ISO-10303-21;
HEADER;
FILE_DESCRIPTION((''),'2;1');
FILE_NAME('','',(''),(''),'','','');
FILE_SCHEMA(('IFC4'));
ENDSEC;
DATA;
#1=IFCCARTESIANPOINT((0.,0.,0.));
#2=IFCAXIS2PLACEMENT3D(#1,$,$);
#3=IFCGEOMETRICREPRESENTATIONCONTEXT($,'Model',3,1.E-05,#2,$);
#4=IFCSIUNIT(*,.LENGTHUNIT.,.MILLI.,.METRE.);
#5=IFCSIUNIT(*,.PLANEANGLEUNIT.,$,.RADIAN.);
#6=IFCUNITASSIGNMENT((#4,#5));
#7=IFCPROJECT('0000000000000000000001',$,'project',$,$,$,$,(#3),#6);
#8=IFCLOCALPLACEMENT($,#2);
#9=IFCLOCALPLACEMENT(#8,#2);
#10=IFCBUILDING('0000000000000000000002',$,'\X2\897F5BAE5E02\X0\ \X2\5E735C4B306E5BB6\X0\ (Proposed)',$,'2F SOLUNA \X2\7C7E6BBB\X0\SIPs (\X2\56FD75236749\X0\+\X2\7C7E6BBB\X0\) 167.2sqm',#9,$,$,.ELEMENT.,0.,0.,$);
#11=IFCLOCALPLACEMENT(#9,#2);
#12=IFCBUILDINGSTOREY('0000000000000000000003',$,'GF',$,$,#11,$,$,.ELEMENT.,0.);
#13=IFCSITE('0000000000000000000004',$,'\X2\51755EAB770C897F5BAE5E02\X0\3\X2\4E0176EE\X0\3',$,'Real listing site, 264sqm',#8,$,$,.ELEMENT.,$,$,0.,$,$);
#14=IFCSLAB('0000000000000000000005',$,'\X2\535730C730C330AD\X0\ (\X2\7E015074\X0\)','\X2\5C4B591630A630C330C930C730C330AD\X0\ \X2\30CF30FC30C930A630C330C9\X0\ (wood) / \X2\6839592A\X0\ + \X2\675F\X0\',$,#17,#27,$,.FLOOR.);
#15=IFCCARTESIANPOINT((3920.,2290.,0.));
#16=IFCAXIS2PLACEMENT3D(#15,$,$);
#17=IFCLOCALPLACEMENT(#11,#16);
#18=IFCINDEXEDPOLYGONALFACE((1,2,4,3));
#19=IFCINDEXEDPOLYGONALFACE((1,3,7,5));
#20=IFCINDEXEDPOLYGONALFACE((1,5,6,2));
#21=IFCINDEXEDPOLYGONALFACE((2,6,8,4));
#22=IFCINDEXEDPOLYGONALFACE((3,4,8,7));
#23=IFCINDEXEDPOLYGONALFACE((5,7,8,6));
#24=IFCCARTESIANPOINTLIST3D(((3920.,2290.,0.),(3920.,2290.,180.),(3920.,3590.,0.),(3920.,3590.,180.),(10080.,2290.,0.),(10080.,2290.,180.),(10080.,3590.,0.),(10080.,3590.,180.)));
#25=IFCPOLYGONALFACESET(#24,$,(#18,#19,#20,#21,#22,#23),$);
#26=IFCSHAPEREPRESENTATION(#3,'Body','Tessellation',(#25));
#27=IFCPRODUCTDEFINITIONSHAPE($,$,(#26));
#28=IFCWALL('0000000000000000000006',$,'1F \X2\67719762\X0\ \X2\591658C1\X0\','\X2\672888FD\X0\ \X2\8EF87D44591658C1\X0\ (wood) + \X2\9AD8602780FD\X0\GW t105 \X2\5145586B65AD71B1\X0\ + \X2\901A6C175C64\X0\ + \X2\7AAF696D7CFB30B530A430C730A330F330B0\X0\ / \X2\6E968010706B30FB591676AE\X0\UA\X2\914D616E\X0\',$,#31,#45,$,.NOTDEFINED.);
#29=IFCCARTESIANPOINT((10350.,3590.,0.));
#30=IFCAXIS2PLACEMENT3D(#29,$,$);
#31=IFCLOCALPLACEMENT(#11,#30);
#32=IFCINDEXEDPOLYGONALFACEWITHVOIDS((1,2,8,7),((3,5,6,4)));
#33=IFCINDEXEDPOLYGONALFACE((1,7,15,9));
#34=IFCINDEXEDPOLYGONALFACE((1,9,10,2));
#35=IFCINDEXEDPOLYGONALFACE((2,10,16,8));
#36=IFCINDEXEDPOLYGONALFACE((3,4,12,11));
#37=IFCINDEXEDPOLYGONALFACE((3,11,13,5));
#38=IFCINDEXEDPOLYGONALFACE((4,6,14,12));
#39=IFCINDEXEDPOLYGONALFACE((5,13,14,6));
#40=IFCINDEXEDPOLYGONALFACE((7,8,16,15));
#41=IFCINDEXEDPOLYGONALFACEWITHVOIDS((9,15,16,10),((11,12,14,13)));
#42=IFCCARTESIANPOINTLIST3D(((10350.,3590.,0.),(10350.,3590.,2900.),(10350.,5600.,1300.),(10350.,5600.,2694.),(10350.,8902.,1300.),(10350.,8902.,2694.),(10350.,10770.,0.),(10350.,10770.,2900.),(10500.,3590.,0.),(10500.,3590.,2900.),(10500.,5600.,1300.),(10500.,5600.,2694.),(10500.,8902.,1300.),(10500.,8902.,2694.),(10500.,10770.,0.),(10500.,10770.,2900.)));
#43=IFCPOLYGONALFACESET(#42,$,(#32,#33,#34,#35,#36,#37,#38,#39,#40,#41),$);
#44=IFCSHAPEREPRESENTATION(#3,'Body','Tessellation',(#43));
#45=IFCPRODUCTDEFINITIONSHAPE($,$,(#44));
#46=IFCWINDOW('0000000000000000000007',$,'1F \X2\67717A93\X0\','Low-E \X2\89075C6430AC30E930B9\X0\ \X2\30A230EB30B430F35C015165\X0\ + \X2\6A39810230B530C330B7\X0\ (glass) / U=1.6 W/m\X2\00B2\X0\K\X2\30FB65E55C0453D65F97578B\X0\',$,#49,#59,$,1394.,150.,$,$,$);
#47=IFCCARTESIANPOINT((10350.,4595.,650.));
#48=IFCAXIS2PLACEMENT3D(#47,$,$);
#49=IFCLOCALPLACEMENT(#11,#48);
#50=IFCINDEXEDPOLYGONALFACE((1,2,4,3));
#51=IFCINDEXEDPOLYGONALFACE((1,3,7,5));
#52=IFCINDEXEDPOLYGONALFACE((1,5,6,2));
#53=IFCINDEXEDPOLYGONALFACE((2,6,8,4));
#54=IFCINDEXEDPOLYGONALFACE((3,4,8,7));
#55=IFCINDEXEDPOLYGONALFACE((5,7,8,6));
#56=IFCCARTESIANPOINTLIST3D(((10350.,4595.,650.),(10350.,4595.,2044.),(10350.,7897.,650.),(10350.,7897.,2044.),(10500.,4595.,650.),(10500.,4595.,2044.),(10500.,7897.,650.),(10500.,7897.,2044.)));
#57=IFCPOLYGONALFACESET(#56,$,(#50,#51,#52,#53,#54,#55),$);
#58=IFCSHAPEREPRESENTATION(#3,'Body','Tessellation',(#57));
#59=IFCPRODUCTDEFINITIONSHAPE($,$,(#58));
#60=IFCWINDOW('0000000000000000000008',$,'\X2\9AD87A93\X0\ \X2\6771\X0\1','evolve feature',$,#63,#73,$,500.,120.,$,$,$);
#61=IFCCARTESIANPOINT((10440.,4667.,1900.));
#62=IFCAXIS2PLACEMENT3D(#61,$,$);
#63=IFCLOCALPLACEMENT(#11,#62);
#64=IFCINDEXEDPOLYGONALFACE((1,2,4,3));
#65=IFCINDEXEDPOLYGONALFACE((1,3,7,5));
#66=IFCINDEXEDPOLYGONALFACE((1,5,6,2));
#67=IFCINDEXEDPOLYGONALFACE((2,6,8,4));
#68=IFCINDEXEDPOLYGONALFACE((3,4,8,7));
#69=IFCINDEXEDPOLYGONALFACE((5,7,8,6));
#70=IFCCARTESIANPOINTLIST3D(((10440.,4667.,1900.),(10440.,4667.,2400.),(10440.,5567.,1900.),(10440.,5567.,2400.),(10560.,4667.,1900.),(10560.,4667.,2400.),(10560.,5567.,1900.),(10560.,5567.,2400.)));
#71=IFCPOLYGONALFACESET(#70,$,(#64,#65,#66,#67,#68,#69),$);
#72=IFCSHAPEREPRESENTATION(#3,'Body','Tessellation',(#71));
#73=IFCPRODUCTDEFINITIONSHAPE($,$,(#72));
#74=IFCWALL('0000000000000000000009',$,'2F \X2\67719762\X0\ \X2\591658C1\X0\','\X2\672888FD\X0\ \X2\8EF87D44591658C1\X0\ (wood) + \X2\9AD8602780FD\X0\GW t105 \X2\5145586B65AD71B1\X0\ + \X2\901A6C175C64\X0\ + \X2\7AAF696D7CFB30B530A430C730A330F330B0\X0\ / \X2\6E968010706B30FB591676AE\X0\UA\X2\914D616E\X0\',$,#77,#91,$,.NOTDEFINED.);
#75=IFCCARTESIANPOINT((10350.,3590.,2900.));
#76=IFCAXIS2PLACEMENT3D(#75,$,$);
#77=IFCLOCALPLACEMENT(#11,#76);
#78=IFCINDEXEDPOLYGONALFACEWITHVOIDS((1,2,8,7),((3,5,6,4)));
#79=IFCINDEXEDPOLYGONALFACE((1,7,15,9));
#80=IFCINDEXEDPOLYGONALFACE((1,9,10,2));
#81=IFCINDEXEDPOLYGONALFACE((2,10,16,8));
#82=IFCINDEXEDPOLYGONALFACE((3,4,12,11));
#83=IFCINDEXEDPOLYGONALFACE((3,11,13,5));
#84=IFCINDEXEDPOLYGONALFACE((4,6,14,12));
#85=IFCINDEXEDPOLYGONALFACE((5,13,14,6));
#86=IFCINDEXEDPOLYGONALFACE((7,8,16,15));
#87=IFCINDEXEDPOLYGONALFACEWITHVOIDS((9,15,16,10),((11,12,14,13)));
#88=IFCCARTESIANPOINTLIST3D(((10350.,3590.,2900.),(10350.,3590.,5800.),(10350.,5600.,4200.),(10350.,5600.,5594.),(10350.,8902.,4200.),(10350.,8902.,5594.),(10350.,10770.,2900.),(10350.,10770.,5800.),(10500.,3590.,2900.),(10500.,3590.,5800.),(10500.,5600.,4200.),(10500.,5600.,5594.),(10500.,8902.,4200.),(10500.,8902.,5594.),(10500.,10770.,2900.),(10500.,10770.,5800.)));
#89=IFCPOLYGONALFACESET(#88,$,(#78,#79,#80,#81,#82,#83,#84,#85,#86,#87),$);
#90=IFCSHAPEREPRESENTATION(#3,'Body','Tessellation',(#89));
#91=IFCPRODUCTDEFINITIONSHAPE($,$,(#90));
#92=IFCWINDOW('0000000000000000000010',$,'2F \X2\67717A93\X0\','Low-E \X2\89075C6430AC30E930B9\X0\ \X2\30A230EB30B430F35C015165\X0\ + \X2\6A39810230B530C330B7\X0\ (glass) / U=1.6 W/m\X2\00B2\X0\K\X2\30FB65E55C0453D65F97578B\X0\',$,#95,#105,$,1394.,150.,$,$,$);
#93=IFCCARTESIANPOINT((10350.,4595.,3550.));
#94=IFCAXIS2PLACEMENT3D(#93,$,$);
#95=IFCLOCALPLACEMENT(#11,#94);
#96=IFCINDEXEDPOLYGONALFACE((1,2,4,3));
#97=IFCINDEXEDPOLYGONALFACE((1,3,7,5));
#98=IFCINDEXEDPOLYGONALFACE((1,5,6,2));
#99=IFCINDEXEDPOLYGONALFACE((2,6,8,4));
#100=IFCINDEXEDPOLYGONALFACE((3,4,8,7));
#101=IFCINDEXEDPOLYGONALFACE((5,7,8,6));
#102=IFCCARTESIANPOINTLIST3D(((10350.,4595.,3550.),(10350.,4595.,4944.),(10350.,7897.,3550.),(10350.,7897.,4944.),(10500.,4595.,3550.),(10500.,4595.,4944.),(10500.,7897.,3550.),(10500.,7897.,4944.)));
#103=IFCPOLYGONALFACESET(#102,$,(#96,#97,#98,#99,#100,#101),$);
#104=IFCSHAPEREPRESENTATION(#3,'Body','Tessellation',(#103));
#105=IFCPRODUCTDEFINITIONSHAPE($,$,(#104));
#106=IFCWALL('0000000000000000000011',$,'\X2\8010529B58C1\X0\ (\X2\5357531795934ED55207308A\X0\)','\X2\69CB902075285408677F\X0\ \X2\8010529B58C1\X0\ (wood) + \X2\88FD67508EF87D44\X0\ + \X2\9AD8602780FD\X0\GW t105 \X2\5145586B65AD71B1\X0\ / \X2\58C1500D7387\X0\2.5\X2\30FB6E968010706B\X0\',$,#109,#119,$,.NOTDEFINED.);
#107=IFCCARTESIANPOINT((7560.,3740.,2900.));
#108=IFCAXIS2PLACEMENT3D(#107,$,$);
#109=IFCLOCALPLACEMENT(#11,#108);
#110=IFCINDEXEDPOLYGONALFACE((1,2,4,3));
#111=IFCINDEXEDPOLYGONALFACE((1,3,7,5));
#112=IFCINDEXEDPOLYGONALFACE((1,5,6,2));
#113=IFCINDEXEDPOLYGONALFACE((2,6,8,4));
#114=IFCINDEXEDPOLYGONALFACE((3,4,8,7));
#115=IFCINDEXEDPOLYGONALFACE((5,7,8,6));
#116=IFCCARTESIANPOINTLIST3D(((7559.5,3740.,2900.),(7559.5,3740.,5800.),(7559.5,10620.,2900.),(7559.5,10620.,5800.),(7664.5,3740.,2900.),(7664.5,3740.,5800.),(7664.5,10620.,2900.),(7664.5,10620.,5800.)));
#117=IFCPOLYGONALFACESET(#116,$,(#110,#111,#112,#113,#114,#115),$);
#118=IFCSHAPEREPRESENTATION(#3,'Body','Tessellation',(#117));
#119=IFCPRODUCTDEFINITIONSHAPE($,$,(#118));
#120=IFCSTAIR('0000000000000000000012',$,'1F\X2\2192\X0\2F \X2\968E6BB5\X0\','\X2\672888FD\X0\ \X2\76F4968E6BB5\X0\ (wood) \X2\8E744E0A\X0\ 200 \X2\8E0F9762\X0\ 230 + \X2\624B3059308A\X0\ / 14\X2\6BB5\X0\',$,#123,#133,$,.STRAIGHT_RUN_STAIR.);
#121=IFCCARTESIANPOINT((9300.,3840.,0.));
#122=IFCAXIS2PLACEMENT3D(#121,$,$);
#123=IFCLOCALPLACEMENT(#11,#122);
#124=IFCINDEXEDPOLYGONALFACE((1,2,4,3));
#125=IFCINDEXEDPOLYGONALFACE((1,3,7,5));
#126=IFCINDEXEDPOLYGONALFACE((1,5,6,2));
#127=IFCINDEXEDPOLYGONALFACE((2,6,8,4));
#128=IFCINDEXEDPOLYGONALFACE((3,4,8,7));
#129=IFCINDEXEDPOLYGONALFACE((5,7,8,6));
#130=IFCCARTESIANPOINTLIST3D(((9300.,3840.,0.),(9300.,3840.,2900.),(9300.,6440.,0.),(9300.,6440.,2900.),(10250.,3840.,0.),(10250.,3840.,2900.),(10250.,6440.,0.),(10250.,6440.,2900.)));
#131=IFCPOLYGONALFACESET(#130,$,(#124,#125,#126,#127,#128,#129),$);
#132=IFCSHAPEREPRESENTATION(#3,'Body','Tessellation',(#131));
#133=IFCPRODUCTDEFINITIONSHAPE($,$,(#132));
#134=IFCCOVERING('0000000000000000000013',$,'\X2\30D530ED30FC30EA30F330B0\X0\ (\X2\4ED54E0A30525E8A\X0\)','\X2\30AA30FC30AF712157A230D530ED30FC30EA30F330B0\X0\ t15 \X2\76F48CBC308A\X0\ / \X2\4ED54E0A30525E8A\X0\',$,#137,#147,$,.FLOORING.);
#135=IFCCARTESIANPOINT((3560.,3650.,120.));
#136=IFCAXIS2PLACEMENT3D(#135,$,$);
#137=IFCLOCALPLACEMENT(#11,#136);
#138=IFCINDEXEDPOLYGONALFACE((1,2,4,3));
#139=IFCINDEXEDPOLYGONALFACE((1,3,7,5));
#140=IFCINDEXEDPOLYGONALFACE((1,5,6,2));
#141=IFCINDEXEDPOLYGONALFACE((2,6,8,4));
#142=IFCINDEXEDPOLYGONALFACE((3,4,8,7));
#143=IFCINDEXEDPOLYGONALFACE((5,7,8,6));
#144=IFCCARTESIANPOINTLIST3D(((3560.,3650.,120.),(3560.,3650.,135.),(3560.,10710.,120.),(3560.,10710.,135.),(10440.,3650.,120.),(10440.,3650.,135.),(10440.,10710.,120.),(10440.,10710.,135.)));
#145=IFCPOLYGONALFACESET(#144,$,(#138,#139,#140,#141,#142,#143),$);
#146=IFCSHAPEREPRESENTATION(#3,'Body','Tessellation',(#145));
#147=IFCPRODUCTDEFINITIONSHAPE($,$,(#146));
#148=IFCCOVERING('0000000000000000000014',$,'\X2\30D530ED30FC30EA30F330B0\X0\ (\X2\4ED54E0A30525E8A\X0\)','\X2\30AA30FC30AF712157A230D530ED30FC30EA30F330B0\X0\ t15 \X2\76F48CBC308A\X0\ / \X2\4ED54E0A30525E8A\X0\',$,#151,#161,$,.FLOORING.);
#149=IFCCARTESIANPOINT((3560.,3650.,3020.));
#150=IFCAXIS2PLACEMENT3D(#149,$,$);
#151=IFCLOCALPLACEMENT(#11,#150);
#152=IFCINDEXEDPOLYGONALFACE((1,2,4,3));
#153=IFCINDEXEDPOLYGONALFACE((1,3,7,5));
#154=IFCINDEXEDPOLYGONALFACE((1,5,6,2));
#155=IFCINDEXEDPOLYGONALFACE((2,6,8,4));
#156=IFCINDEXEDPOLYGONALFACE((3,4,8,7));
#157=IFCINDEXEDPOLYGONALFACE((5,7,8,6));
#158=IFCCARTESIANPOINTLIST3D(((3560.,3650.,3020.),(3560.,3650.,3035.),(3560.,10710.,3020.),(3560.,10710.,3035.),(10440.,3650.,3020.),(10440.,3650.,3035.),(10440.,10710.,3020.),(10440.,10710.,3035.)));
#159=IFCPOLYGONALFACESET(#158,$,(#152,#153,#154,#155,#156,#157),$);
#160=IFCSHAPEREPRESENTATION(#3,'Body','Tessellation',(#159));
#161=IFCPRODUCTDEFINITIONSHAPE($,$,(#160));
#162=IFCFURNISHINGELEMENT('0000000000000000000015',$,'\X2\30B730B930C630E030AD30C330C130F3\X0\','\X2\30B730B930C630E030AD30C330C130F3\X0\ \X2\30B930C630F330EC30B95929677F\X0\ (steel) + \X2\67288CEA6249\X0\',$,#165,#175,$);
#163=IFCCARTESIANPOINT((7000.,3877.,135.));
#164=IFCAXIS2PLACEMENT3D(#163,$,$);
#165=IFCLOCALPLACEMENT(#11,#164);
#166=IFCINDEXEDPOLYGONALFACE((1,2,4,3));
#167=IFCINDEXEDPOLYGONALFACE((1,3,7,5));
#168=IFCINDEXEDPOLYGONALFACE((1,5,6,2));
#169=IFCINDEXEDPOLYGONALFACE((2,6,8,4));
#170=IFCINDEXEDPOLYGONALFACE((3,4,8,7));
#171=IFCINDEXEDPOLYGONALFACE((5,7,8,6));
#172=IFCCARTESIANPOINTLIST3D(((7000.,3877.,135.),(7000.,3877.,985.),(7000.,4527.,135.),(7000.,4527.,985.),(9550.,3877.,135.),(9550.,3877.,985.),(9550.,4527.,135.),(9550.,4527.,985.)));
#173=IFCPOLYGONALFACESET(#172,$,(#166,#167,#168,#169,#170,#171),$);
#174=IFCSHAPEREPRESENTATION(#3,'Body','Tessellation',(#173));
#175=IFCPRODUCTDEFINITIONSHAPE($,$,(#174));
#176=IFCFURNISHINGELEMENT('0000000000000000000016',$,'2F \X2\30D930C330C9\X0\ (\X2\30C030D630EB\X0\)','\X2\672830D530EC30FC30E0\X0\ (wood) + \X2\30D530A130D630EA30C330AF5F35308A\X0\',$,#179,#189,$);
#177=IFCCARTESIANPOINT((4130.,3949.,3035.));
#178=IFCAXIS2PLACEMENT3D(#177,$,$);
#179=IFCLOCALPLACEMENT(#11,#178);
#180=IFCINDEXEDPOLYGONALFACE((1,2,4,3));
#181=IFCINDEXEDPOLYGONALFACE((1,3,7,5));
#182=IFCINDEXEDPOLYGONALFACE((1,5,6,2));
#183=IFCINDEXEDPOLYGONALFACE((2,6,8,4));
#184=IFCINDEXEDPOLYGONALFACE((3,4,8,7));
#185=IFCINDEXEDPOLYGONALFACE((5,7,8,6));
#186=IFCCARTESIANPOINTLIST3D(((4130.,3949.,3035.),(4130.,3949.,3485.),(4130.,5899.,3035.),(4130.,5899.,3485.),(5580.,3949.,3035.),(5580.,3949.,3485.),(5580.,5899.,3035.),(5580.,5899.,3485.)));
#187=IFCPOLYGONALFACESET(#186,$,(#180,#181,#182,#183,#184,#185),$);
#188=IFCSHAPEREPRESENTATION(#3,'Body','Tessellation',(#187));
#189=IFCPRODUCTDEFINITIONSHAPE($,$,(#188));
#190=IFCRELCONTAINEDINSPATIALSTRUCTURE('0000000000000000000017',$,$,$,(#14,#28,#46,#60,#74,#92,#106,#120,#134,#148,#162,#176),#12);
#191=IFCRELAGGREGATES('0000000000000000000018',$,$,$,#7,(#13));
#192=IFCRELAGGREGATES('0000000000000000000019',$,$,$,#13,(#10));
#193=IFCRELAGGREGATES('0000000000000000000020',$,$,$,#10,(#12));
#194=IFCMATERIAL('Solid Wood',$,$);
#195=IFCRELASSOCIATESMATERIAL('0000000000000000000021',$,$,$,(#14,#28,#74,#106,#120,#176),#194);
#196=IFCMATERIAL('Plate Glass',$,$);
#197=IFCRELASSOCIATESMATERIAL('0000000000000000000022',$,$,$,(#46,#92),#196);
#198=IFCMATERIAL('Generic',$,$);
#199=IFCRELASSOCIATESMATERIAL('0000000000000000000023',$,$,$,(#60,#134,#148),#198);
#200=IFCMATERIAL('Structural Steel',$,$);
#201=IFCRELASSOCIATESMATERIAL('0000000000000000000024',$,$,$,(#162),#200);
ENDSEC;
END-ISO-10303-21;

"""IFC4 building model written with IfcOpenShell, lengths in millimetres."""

from ifc_helpers import new_model, si_unit, frame, frame_2d, origin, place, context, project, spatial, rectangle, extrude, material, element, fill, save


model = new_model("IFC4")

# Units and contexts
model_context = context("Model", 3, precision=1e-05, world=origin())
ifc_project = project(units=[si_unit("LENGTHUNIT", "METRE", prefix="MILLI"), si_unit("PLANEANGLEUNIT", "RADIAN")], contexts=[model_context])

# Site, building, storey
site_placement = place(None, origin())
site = spatial("IfcSite", under=ifc_project, at=site_placement, Name="兵庫県西宮市3丁目3", ObjectType="Real listing site, 264sqm", CompositionType="ELEMENT", RefElevation=0.0)
building_placement = place(site_placement, origin())
building = spatial("IfcBuilding", under=site, at=building_placement, Name="西宮市 平屋の家 (Proposed)", ObjectType="2F SOLUNA 籾殻SIPs (国産杉+籾殻) 167.2sqm", CompositionType="ELEMENT", ElevationOfRefHeight=0.0, ElevationOfTerrain=0.0)
storey_placement = place(building_placement, origin())
storey = spatial("IfcBuildingStorey", under=building, at=storey_placement, Name="GF", CompositionType="ELEMENT", Elevation=0.0)

# Slab
ifc_material_1 = material(Name="Solid Wood")
slab_placement = place(storey_placement, frame((3920.0, 2290.0, 0.0)))
element("IfcSlab", 1, at=slab_placement, inside=storey, material=ifc_material_1, Name="南デッキ (縁側)", Description="屋外ウッドデッキ ハードウッド (wood) / 根太 + 束", PredefinedType="FLOOR", context=model_context, shape_type="SweptSolid", body=[
    extrude(rectangle(XDim=6160.0, YDim=1300.0, at=frame_2d((3080.0, 650.0))), frame((3920.0, 2290.0, 0.0)), (0.0, 0.0, 1.0), 180.0),
])

# Wall, openings, windows
wall_1_placement = place(storey_placement, frame((10350.0, 3590.0, 0.0)))
wall_1 = element("IfcWall", 2, at=wall_1_placement, inside=storey, material=ifc_material_1, Name="1F 東面 外壁", Description="木製 軸組外壁 (wood) + 高性能GW t105 充填断熱 + 通気層 + 窯業系サイディング / 準耐火・外皮UA配慮", PredefinedType="NOTDEFINED", context=model_context, shape_type="SweptSolid", body=[
    extrude(rectangle(XDim=150.0, YDim=7180.0, at=frame_2d((75.0, 3590.0))), frame((10350.0, 3590.0, 0.0)), (0.0, 0.0, 1.0), 2900.0),
])
opening_1_placement = place(storey_placement, frame((10350.0, 4595.0, 650.0)))
opening_1 = element("IfcOpeningElement", 3, at=opening_1_placement, cuts=wall_1, PredefinedType="NOTDEFINED", context=model_context, shape_type="SweptSolid", body=[
    extrude(rectangle(XDim=150.0, YDim=3302.0, at=frame_2d((75.0, 1651.0))), frame((10350.0, 4595.0, 650.0)), (0.0, 0.0, 1.0), 1394.0),
])
opening_2_placement = place(storey_placement, frame((10440.0, 4667.0, 1900.0)))
opening_2 = element("IfcOpeningElement", 4, at=opening_2_placement, cuts=wall_1, PredefinedType="NOTDEFINED", context=model_context, shape_type="SweptSolid", body=[
    extrude(rectangle(XDim=120.0, YDim=900.0, at=frame_2d((60.0, 450.0))), frame((10440.0, 4667.0, 1900.0)), (0.0, 0.0, 1.0), 500.0),
])
ifc_material_2 = material(Name="Plate Glass")
window_1_placement = place(storey_placement, frame((10350.0, 4595.0, 650.0)))
window_1 = element("IfcWindow", 5, at=window_1_placement, inside=storey, material=ifc_material_2, Name="1F 東窓", Description="Low-E 複層ガラス アルゴン封入 + 樹脂サッシ (glass) / U=1.6 W/m²K・日射取得型", OverallHeight=1394.0, OverallWidth=150.0, context=model_context, shape_type="SweptSolid", body=[
    extrude(rectangle(XDim=150.0, YDim=3302.0, at=frame_2d((75.0, 1651.0))), frame((10350.0, 4595.0, 650.0)), (0.0, 0.0, 1.0), 1394.0),
])
fill(opening_1, window_1)
ifc_material_3 = material(Name="Generic")
window_2_placement = place(storey_placement, frame((10440.0, 4667.0, 1900.0)))
window_2 = element("IfcWindow", 6, at=window_2_placement, inside=storey, material=ifc_material_3, Name="高窓 東1", Description="evolve feature", OverallHeight=500.0, OverallWidth=120.0, context=model_context, shape_type="SweptSolid", body=[
    extrude(rectangle(XDim=120.0, YDim=900.0, at=frame_2d((60.0, 450.0))), frame((10440.0, 4667.0, 1900.0)), (0.0, 0.0, 1.0), 500.0),
])
fill(opening_2, window_2)

# Wall, opening, window
wall_2_placement = place(storey_placement, frame((10350.0, 3590.0, 2900.0)))
wall_2 = element("IfcWall", 7, at=wall_2_placement, inside=storey, material=ifc_material_1, Name="2F 東面 外壁", Description="木製 軸組外壁 (wood) + 高性能GW t105 充填断熱 + 通気層 + 窯業系サイディング / 準耐火・外皮UA配慮", PredefinedType="NOTDEFINED", context=model_context, shape_type="SweptSolid", body=[
    extrude(rectangle(XDim=150.0, YDim=7180.0, at=frame_2d((75.0, 3590.0))), frame((10350.0, 3590.0, 2900.0)), (0.0, 0.0, 1.0), 2900.0),
])
opening_3_placement = place(storey_placement, frame((10350.0, 4595.0, 3550.0)))
opening_3 = element("IfcOpeningElement", 8, at=opening_3_placement, cuts=wall_2, PredefinedType="NOTDEFINED", context=model_context, shape_type="SweptSolid", body=[
    extrude(rectangle(XDim=150.0, YDim=3302.0, at=frame_2d((75.0, 1651.0))), frame((10350.0, 4595.0, 3550.0)), (0.0, 0.0, 1.0), 1394.0),
])
window_3_placement = place(storey_placement, frame((10350.0, 4595.0, 3550.0)))
window_3 = element("IfcWindow", 9, at=window_3_placement, inside=storey, material=ifc_material_2, Name="2F 東窓", Description="Low-E 複層ガラス アルゴン封入 + 樹脂サッシ (glass) / U=1.6 W/m²K・日射取得型", OverallHeight=1394.0, OverallWidth=150.0, context=model_context, shape_type="SweptSolid", body=[
    extrude(rectangle(XDim=150.0, YDim=3302.0, at=frame_2d((75.0, 1651.0))), frame((10350.0, 4595.0, 3550.0)), (0.0, 0.0, 1.0), 1394.0),
])
fill(opening_3, window_3)

# Wall
wall_3_placement = place(storey_placement, frame((7560.0, 3740.0, 2900.0)))
element("IfcWall", 10, at=wall_3_placement, inside=storey, material=ifc_material_1, Name="耐力壁 (南北間仕切り)", Description="構造用合板 耐力壁 (wood) + 製材軸組 + 高性能GW t105 充填断熱 / 壁倍率2.5・準耐火", PredefinedType="NOTDEFINED", context=model_context, shape_type="SweptSolid", body=[
    extrude(rectangle(XDim=105.0, YDim=6880.0, at=frame_2d((52.0, 3440.0))), frame((7560.0, 3740.0, 2900.0)), (0.0, 0.0, 1.0), 2900.0),
])

# Stair
stair_placement = place(storey_placement, frame((9300.0, 3840.0, 0.0)))
element("IfcStair", 11, at=stair_placement, inside=storey, material=ifc_material_1, Name="1F→2F 階段", Description="木製 直階段 (wood) 蹴上 200 踏面 230 + 手すり / 14段", PredefinedType="STRAIGHT_RUN_STAIR", context=model_context, shape_type="SweptSolid", body=[
    extrude(rectangle(XDim=950.0, YDim=2600.0, at=frame_2d((475.0, 1300.0))), frame((9300.0, 3840.0, 0.0)), (0.0, 0.0, 1.0), 2900.0),
])

# Coverings
covering_1_placement = place(storey_placement, frame((3560.0, 3650.0, 120.0)))
element("IfcCovering", 12, at=covering_1_placement, inside=storey, material=ifc_material_3, Name="フローリング (仕上げ床)", Description="オーク無垢フローリング t15 直貼り / 仕上げ床", PredefinedType="FLOORING", context=model_context, shape_type="SweptSolid", body=[
    extrude(rectangle(XDim=6880.0, YDim=7060.0, at=frame_2d((3440.0, 3530.0))), frame((3560.0, 3650.0, 120.0)), (0.0, 0.0, 1.0), 15.0),
])
covering_2_placement = place(storey_placement, frame((3560.0, 3650.0, 3020.0)))
element("IfcCovering", 13, at=covering_2_placement, inside=storey, material=ifc_material_3, Name="フローリング (仕上げ床)", Description="オーク無垢フローリング t15 直貼り / 仕上げ床", PredefinedType="FLOORING", context=model_context, shape_type="SweptSolid", body=[
    extrude(rectangle(XDim=6880.0, YDim=7060.0, at=frame_2d((3440.0, 3530.0))), frame((3560.0, 3650.0, 3020.0)), (0.0, 0.0, 1.0), 15.0),
])

# Furnishing elements
ifc_material_4 = material(Name="Structural Steel")
furnishing_1_placement = place(storey_placement, frame((7000.0, 3877.0, 135.0)))
element("IfcFurnishingElement", 14, at=furnishing_1_placement, inside=storey, material=ifc_material_4, Name="システムキッチン", Description="システムキッチン ステンレス天板 (steel) + 木質扉", context=model_context, shape_type="SweptSolid", body=[
    extrude(rectangle(XDim=2550.0, YDim=650.0, at=frame_2d((1275.0, 325.0))), frame((7000.0, 3877.0, 135.0)), (0.0, 0.0, 1.0), 850.0),
])
furnishing_2_placement = place(storey_placement, frame((4130.0, 3949.0, 3035.0)))
element("IfcFurnishingElement", 15, at=furnishing_2_placement, inside=storey, material=ifc_material_1, Name="2F ベッド (ダブル)", Description="木フレーム (wood) + ファブリック張り", context=model_context, shape_type="SweptSolid", body=[
    extrude(rectangle(XDim=1450.0, YDim=1950.0, at=frame_2d((725.0, 975.0))), frame((4130.0, 3949.0, 3035.0)), (0.0, 0.0, 1.0), 450.0),
])

save(model, "model.ifc")
